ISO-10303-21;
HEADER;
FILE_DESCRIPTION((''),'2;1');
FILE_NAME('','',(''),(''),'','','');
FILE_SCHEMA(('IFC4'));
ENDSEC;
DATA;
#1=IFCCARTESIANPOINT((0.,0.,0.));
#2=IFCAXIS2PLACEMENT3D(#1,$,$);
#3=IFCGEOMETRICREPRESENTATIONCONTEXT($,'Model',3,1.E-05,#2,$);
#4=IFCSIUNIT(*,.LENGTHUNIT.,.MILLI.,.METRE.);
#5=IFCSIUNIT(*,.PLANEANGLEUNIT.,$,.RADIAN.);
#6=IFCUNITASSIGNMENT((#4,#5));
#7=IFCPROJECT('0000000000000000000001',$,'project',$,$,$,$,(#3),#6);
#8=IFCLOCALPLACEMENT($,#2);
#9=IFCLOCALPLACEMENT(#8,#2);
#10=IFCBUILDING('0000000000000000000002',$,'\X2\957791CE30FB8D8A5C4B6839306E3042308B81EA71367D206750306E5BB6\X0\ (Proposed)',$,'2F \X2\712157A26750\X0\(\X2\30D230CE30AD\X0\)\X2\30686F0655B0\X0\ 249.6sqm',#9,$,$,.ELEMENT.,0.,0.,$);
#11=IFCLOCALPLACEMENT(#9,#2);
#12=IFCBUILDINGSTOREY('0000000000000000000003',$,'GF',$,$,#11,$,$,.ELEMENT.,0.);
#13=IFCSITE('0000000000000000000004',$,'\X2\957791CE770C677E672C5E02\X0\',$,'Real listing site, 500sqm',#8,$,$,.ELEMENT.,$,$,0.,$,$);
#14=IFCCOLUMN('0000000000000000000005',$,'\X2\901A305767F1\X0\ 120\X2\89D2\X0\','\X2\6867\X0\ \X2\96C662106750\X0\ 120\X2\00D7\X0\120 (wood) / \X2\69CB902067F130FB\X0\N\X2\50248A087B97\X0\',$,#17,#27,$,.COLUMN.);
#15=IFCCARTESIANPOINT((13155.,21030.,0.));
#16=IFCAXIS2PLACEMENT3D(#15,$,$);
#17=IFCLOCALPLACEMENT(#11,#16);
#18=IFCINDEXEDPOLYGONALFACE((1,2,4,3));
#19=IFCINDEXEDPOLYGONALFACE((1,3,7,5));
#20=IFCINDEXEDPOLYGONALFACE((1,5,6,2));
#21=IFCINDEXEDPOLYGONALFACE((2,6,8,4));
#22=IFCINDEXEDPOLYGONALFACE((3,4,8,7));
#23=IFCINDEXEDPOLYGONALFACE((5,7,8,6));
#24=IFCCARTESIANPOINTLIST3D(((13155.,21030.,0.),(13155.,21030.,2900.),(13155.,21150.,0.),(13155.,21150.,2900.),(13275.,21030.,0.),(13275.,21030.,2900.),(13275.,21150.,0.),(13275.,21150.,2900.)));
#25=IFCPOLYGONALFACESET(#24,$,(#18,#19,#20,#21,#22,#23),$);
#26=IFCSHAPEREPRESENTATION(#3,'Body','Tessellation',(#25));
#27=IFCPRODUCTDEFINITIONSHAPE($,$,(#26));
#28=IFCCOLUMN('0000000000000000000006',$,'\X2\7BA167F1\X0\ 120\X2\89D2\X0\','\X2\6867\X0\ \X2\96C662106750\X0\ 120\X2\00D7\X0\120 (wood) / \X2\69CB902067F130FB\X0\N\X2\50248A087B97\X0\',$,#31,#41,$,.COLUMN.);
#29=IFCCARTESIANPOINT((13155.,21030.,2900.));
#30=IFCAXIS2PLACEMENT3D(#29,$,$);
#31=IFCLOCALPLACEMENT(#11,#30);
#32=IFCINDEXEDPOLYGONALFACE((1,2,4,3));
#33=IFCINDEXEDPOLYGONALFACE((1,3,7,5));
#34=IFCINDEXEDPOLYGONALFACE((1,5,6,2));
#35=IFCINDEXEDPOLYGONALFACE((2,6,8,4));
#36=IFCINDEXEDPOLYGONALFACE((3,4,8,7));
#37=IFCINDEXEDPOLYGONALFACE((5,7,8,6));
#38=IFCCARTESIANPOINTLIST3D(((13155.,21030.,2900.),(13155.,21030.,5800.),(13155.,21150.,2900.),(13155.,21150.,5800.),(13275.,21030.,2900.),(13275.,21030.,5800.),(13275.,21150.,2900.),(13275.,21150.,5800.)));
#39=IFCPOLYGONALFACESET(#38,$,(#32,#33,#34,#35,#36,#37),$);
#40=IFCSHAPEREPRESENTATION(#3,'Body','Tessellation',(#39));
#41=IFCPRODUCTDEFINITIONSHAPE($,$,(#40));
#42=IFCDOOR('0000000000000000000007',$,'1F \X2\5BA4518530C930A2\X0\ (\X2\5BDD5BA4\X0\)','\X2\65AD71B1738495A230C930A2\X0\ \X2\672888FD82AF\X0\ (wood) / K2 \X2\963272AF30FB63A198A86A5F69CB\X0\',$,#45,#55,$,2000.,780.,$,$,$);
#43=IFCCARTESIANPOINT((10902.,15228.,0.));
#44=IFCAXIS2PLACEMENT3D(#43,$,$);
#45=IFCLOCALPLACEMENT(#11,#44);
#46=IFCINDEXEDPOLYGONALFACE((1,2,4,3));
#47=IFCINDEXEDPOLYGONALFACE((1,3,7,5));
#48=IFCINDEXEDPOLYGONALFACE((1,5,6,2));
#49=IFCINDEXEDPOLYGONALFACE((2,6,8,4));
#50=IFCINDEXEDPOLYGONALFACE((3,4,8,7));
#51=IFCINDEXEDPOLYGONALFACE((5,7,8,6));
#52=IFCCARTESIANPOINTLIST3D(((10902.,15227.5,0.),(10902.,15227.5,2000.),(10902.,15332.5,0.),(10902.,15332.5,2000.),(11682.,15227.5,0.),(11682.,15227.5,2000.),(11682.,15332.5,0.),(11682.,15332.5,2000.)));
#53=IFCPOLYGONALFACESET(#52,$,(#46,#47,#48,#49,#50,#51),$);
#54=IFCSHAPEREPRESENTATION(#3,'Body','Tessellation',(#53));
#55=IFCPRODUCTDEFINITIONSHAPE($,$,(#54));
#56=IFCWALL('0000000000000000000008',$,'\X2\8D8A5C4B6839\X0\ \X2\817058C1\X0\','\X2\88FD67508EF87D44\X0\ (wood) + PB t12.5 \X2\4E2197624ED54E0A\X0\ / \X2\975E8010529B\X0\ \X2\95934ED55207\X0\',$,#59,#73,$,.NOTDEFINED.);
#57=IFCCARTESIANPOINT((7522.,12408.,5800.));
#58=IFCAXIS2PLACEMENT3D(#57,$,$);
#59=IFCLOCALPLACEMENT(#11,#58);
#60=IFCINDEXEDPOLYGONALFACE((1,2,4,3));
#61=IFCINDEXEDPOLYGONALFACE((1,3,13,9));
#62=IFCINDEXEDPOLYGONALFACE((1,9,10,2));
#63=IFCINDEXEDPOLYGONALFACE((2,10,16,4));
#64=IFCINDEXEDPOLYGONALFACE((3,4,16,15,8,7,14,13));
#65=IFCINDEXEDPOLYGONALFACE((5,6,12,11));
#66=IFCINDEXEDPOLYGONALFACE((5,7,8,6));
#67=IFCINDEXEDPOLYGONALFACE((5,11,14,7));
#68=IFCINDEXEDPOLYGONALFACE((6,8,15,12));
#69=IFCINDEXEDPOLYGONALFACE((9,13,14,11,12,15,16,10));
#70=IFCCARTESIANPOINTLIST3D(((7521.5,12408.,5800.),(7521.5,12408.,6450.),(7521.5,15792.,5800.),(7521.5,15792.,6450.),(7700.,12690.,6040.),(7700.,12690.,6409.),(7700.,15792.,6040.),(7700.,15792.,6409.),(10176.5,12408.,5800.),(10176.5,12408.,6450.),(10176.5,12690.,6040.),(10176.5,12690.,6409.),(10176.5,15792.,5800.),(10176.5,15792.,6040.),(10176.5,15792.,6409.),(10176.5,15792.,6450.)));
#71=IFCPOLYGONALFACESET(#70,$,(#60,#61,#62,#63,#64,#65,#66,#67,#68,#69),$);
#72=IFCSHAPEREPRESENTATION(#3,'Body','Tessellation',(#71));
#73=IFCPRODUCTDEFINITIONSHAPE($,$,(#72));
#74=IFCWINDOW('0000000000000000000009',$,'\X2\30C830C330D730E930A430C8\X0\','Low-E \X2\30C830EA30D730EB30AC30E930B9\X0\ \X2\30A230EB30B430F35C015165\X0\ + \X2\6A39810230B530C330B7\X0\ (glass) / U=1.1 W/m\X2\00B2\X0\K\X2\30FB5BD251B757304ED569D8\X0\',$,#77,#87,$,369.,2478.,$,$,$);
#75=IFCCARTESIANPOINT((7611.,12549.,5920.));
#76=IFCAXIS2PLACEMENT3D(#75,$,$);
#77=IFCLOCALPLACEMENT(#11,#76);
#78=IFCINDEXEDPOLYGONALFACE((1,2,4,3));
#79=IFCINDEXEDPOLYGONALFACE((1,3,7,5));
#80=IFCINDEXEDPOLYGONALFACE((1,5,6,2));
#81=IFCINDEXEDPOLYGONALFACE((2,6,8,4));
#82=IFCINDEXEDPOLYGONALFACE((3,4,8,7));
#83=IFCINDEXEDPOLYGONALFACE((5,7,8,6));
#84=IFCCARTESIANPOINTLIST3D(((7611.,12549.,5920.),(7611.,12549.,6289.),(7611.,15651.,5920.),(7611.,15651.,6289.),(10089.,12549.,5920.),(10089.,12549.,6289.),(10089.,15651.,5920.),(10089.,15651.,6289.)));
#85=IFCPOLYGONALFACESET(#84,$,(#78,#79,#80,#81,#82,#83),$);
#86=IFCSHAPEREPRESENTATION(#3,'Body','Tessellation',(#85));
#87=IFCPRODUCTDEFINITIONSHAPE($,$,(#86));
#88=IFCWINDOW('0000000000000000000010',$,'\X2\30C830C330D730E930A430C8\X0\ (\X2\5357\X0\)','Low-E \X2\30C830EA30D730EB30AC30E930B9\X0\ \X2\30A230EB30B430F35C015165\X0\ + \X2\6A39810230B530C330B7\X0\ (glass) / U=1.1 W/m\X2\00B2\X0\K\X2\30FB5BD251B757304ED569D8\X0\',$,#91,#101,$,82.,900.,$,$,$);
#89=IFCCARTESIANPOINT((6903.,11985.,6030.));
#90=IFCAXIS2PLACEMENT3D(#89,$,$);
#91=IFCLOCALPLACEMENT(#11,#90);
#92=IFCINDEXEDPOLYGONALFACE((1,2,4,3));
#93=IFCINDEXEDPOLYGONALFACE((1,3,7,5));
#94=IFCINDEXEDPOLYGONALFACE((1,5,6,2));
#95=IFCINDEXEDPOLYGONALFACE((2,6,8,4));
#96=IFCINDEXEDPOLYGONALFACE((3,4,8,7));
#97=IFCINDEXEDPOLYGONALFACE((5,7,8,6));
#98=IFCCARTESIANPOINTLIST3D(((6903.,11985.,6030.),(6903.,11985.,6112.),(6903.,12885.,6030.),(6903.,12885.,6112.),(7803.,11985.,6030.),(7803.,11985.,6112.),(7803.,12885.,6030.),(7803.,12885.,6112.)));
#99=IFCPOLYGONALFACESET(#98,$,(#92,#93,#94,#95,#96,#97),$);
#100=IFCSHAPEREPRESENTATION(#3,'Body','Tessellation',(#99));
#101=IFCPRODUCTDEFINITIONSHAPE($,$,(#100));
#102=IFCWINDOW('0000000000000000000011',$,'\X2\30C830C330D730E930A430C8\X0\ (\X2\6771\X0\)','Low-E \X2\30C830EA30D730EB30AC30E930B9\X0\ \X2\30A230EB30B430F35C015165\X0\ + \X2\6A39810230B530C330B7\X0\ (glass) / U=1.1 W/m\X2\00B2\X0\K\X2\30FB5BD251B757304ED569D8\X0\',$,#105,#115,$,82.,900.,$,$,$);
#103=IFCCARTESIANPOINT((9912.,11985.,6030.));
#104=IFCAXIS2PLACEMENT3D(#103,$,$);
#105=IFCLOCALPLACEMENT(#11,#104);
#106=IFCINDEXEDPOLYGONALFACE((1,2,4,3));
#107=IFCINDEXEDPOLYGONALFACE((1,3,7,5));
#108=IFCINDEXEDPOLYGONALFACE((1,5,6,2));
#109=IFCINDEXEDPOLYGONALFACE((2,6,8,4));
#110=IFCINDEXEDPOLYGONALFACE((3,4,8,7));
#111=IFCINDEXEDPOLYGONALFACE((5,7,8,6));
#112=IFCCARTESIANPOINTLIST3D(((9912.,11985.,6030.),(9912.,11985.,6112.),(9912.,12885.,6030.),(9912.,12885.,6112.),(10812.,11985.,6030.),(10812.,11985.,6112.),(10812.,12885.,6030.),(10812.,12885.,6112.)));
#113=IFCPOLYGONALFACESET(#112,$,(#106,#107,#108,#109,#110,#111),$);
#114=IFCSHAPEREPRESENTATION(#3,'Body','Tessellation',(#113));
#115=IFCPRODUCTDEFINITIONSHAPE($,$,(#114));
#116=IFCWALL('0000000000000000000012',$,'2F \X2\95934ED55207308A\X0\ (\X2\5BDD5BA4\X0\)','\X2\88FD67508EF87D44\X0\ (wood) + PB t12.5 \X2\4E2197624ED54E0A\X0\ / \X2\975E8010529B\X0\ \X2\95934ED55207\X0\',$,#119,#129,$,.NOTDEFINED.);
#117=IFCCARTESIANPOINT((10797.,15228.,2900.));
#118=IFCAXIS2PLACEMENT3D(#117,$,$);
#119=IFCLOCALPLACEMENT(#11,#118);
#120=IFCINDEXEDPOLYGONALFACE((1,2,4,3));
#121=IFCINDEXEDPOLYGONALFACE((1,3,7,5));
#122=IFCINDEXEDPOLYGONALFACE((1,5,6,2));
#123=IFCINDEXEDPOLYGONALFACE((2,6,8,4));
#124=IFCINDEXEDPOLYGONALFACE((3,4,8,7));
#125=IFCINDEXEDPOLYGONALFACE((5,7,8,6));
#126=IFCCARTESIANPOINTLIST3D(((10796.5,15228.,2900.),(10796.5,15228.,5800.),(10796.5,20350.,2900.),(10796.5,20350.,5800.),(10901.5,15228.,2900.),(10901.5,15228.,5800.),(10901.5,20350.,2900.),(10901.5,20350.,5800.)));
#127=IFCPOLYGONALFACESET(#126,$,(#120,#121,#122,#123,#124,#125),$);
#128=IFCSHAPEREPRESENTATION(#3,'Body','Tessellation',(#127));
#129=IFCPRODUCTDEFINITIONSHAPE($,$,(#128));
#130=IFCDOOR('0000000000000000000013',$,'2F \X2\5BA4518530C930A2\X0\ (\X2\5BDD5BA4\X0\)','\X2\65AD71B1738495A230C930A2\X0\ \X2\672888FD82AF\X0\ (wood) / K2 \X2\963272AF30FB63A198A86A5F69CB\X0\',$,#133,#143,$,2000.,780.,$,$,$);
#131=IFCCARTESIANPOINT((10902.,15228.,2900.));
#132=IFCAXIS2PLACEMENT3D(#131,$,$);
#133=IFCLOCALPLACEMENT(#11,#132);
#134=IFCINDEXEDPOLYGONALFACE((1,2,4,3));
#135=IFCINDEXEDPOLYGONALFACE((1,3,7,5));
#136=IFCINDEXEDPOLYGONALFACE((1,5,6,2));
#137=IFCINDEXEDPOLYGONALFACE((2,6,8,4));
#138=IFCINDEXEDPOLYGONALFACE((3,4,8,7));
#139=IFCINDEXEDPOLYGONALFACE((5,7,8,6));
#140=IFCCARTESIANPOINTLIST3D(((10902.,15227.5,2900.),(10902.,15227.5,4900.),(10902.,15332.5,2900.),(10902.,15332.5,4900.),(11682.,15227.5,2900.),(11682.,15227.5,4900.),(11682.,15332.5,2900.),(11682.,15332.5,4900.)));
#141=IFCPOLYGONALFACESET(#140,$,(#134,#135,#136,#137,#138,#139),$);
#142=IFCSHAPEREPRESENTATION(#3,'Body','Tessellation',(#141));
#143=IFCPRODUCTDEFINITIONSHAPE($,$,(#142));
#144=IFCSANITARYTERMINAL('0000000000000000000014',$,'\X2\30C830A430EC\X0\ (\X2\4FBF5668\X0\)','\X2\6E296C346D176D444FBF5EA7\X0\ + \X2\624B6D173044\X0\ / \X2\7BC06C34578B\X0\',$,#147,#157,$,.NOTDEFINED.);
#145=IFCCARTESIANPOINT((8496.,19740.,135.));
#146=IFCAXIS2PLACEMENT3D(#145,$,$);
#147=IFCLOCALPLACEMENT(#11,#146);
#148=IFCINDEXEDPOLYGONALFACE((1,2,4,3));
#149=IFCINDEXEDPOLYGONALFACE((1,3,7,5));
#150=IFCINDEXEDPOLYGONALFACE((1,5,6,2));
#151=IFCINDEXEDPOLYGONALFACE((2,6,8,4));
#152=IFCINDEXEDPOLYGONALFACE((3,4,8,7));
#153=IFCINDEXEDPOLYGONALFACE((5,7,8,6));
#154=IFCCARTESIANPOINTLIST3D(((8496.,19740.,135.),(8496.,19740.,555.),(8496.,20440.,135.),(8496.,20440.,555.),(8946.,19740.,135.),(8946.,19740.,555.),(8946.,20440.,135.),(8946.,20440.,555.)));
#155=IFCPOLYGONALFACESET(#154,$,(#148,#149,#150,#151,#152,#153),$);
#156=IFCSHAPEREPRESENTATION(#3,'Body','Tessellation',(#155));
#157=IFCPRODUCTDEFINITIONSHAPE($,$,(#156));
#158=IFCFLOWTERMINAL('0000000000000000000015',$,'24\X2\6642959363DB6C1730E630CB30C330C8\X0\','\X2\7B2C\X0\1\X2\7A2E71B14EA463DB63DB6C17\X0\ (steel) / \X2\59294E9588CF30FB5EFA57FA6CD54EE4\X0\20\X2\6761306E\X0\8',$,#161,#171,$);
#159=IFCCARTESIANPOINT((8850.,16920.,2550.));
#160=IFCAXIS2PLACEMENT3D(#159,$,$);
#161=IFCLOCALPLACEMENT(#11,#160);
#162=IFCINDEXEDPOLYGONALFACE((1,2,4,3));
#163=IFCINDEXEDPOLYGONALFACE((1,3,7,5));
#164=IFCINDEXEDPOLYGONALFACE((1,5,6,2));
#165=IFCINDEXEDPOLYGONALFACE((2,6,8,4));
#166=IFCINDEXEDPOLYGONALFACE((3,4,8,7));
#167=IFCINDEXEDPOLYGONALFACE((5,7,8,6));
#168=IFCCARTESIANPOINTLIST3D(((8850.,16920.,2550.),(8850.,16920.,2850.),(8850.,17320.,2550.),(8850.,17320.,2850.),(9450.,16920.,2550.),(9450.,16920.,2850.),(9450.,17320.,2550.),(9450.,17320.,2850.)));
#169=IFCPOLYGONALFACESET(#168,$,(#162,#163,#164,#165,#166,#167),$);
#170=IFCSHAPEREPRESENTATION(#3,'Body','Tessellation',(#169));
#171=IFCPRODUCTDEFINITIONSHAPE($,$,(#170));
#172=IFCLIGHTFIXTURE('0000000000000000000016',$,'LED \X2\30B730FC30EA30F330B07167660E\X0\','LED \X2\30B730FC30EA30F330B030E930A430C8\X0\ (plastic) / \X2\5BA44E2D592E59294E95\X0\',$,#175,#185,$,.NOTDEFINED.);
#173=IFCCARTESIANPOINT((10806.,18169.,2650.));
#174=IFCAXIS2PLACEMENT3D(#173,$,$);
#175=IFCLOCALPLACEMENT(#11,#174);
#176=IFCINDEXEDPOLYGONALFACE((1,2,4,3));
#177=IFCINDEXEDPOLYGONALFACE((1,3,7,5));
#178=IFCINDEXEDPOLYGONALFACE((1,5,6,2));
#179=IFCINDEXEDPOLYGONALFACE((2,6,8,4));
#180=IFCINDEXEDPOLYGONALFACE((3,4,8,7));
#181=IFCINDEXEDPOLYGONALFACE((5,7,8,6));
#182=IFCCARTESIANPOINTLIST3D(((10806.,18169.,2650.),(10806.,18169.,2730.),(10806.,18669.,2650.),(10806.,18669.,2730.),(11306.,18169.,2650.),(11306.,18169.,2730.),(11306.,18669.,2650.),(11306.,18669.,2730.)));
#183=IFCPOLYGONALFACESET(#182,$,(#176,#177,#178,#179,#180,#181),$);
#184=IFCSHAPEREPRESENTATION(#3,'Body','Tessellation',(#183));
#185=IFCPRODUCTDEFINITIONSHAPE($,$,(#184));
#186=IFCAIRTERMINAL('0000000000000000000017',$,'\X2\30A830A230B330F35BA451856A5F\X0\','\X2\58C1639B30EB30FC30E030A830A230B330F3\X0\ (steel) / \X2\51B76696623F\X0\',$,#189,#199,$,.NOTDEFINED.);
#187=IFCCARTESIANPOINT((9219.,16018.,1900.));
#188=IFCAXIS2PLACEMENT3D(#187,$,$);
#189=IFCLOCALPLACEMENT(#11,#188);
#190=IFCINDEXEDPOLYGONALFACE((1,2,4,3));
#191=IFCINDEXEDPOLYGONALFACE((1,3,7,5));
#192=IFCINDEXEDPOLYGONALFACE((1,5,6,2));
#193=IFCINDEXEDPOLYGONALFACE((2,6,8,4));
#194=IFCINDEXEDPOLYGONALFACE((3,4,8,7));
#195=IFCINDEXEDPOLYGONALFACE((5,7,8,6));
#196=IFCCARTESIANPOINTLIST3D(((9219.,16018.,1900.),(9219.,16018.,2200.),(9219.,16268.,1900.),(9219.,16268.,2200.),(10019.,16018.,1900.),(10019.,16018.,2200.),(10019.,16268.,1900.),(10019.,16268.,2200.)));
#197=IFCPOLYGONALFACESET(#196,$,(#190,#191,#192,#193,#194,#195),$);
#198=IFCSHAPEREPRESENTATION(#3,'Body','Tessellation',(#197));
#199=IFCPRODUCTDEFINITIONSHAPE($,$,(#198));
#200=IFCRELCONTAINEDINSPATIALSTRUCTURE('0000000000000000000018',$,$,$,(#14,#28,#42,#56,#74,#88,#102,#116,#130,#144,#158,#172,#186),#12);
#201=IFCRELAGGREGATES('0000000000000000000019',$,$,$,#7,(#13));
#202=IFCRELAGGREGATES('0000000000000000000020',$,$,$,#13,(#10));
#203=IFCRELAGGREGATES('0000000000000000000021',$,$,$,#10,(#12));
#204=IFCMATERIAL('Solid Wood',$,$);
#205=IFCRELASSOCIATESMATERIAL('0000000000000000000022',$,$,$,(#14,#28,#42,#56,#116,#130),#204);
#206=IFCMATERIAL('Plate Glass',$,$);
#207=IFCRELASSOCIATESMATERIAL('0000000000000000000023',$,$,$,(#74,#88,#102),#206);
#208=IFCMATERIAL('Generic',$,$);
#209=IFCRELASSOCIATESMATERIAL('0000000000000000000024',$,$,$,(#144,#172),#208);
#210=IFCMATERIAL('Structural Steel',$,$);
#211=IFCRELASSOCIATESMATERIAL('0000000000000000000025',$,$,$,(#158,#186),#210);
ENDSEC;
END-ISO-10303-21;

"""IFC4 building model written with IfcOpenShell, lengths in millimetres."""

from ifc_helpers import new_model, si_unit, frame, frame_2d, origin, place, context, project, spatial, rectangle, extrude, material, element, fill, save


model = new_model("IFC4")

# Units and contexts
model_context = context("Model", 3, precision=1e-05, world=origin())
ifc_project = project(units=[si_unit("LENGTHUNIT", "METRE", prefix="MILLI"), si_unit("PLANEANGLEUNIT", "RADIAN")], contexts=[model_context])

# Site, building, storey
site_placement = place(None, origin())
site = spatial("IfcSite", under=ifc_project, at=site_placement, Name="長野県松本市", ObjectType="Real listing site, 500sqm", CompositionType="ELEMENT", RefElevation=0.0)
building_placement = place(site_placement, origin())
building = spatial("IfcBuilding", under=site, at=building_placement, Name="長野・越屋根のある自然素材の家 (Proposed)", ObjectType="2F 無垢材(ヒノキ)と漆喰 249.6sqm", CompositionType="ELEMENT", ElevationOfRefHeight=0.0, ElevationOfTerrain=0.0)
storey_placement = place(building_placement, origin())
storey = spatial("IfcBuildingStorey", under=building, at=storey_placement, Name="GF", CompositionType="ELEMENT", Elevation=0.0)

# Columns
ifc_material_1 = material(Name="Solid Wood")
column_1_placement = place(storey_placement, frame((13155.0, 21030.0, 0.0)))
element("IfcColumn", 1, at=column_1_placement, inside=storey, material=ifc_material_1, Name="通し柱 120角", Description="桧 集成材 120×120 (wood) / 構造柱・N値計算", PredefinedType="COLUMN", context=model_context, shape_type="SweptSolid", body=[
    extrude(rectangle(XDim=120.0, YDim=120.0, at=frame_2d((60.0, 60.0))), frame((13155.0, 21030.0, 0.0)), (0.0, 0.0, 1.0), 2900.0),
])
column_2_placement = place(storey_placement, frame((13155.0, 21030.0, 2900.0)))
element("IfcColumn", 2, at=column_2_placement, inside=storey, material=ifc_material_1, Name="管柱 120角", Description="桧 集成材 120×120 (wood) / 構造柱・N値計算", PredefinedType="COLUMN", context=model_context, shape_type="SweptSolid", body=[
    extrude(rectangle(XDim=120.0, YDim=120.0, at=frame_2d((60.0, 60.0))), frame((13155.0, 21030.0, 2900.0)), (0.0, 0.0, 1.0), 2900.0),
])

# Door
door_1_placement = place(storey_placement, frame((10902.0, 15228.0, 0.0)))
element("IfcDoor", 3, at=door_1_placement, inside=storey, material=ifc_material_1, Name="1F 室内ドア (寝室)", Description="断熱玄関ドア 木製芯 (wood) / K2 防犯・採風機構", OverallHeight=2000.0, OverallWidth=780.0, context=model_context, shape_type="SweptSolid", body=[
    extrude(rectangle(XDim=780.0, YDim=105.0, at=frame_2d((390.0, 52.0))), frame((10902.0, 15228.0, 0.0)), (0.0, 0.0, 1.0), 2000.0),
])

# Wall, openings, windows
wall_1_placement = place(storey_placement, frame((7522.0, 12408.0, 5800.0)))
wall_1 = element("IfcWall", 4, at=wall_1_placement, inside=storey, material=ifc_material_1, Name="越屋根 腰壁", Description="製材軸組 (wood) + PB t12.5 両面仕上 / 非耐力 間仕切", PredefinedType="NOTDEFINED", context=model_context, shape_type="SweptSolid", body=[
    extrude(rectangle(XDim=2655.0, YDim=3384.0, at=frame_2d((1327.0, 1692.0))), frame((7522.0, 12408.0, 5800.0)), (0.0, 0.0, 1.0), 650.0),
])
opening_1_placement = place(storey_placement, frame((7611.0, 12549.0, 5920.0)))
opening_1 = element("IfcOpeningElement", 5, at=opening_1_placement, cuts=wall_1, PredefinedType="NOTDEFINED", context=model_context, shape_type="SweptSolid", body=[
    extrude(rectangle(XDim=2478.0, YDim=3102.0, at=frame_2d((1239.0, 1551.0))), frame((7611.0, 12549.0, 5920.0)), (0.0, 0.0, 1.0), 369.0),
])
opening_2_placement = place(storey_placement, frame((6903.0, 11985.0, 6030.0)))
opening_2 = element("IfcOpeningElement", 6, at=opening_2_placement, cuts=wall_1, PredefinedType="NOTDEFINED", context=model_context, shape_type="SweptSolid", body=[
    extrude(rectangle(XDim=900.0, YDim=900.0, at=frame_2d((450.0, 450.0))), frame((6903.0, 11985.0, 6030.0)), (0.0, 0.0, 1.0), 82.0),
])
opening_3_placement = place(storey_placement, frame((9912.0, 11985.0, 6030.0)))
opening_3 = element("IfcOpeningElement", 7, at=opening_3_placement, cuts=wall_1, PredefinedType="NOTDEFINED", context=model_context, shape_type="SweptSolid", body=[
    extrude(rectangle(XDim=900.0, YDim=900.0, at=frame_2d((450.0, 450.0))), frame((9912.0, 11985.0, 6030.0)), (0.0, 0.0, 1.0), 82.0),
])
ifc_material_2 = material(Name="Plate Glass")
window_1_placement = place(storey_placement, frame((7611.0, 12549.0, 5920.0)))
window_1 = element("IfcWindow", 8, at=window_1_placement, inside=storey, material=ifc_material_2, Name="トップライト", Description="Low-E トリプルガラス アルゴン封入 + 樹脂サッシ (glass) / U=1.1 W/m²K・寒冷地仕様", OverallHeight=369.0, OverallWidth=2478.0, context=model_context, shape_type="SweptSolid", body=[
    extrude(rectangle(XDim=2478.0, YDim=3102.0, at=frame_2d((1239.0, 1551.0))), frame((7611.0, 12549.0, 5920.0)), (0.0, 0.0, 1.0), 369.0),
])
fill(opening_1, window_1)
window_2_placement = place(storey_placement, frame((6903.0, 11985.0, 6030.0)))
window_2 = element("IfcWindow", 9, at=window_2_placement, inside=storey, material=ifc_material_2, Name="トップライト (南)", Description="Low-E トリプルガラス アルゴン封入 + 樹脂サッシ (glass) / U=1.1 W/m²K・寒冷地仕様", OverallHeight=82.0, OverallWidth=900.0, context=model_context, shape_type="SweptSolid", body=[
    extrude(rectangle(XDim=900.0, YDim=900.0, at=frame_2d((450.0, 450.0))), frame((6903.0, 11985.0, 6030.0)), (0.0, 0.0, 1.0), 82.0),
])
fill(opening_2, window_2)
window_3_placement = place(storey_placement, frame((9912.0, 11985.0, 6030.0)))
window_3 = element("IfcWindow", 10, at=window_3_placement, inside=storey, material=ifc_material_2, Name="トップライト (東)", Description="Low-E トリプルガラス アルゴン封入 + 樹脂サッシ (glass) / U=1.1 W/m²K・寒冷地仕様", OverallHeight=82.0, OverallWidth=900.0, context=model_context, shape_type="SweptSolid", body=[
    extrude(rectangle(XDim=900.0, YDim=900.0, at=frame_2d((450.0, 450.0))), frame((9912.0, 11985.0, 6030.0)), (0.0, 0.0, 1.0), 82.0),
])
fill(opening_3, window_3)

# Wall
wall_2_placement = place(storey_placement, frame((10797.0, 15228.0, 2900.0)))
element("IfcWall", 11, at=wall_2_placement, inside=storey, material=ifc_material_1, Name="2F 間仕切り (寝室)", Description="製材軸組 (wood) + PB t12.5 両面仕上 / 非耐力 間仕切", PredefinedType="NOTDEFINED", context=model_context, shape_type="SweptSolid", body=[
    extrude(rectangle(XDim=105.0, YDim=5122.0, at=frame_2d((52.0, 2561.0))), frame((10797.0, 15228.0, 2900.0)), (0.0, 0.0, 1.0), 2900.0),
])

# Door
door_2_placement = place(storey_placement, frame((10902.0, 15228.0, 2900.0)))
element("IfcDoor", 12, at=door_2_placement, inside=storey, material=ifc_material_1, Name="2F 室内ドア (寝室)", Description="断熱玄関ドア 木製芯 (wood) / K2 防犯・採風機構", OverallHeight=2000.0, OverallWidth=780.0, context=model_context, shape_type="SweptSolid", body=[
    extrude(rectangle(XDim=780.0, YDim=105.0, at=frame_2d((390.0, 52.0))), frame((10902.0, 15228.0, 2900.0)), (0.0, 0.0, 1.0), 2000.0),
])

# Sanitary terminal
ifc_material_3 = material(Name="Generic")
sanitary_terminal_placement = place(storey_placement, frame((8496.0, 19740.0, 135.0)))
element("IfcSanitaryTerminal", 13, at=sanitary_terminal_placement, inside=storey, material=ifc_material_3, Name="トイレ (便器)", Description="温水洗浄便座 + 手洗い / 節水型", PredefinedType="NOTDEFINED", context=model_context, shape_type="SweptSolid", body=[
    extrude(rectangle(XDim=450.0, YDim=700.0, at=frame_2d((225.0, 350.0))), frame((8496.0, 19740.0, 135.0)), (0.0, 0.0, 1.0), 420.0),
])

# Flow terminal
ifc_material_4 = material(Name="Structural Steel")
flow_terminal_placement = place(storey_placement, frame((8850.0, 16920.0, 2550.0)))
element("IfcFlowTerminal", 14, at=flow_terminal_placement, inside=storey, material=ifc_material_4, Name="24時間換気ユニット", Description="第1種熱交換換気 (steel) / 天井裏・建基法令20条の8", context=model_context, shape_type="SweptSolid", body=[
    extrude(rectangle(XDim=600.0, YDim=400.0, at=frame_2d((300.0, 200.0))), frame((8850.0, 16920.0, 2550.0)), (0.0, 0.0, 1.0), 300.0),
])

# Light fixture
light_fixture_1_placement = place(storey_placement, frame((10806.0, 18169.0, 2650.0)))
element("IfcLightFixture", 15, at=light_fixture_1_placement, inside=storey, material=ifc_material_3, Name="LED シーリング照明", Description="LED シーリングライト (plastic) / 室中央天井", PredefinedType="NOTDEFINED", context=model_context, shape_type="SweptSolid", body=[
    extrude(rectangle(XDim=500.0, YDim=500.0, at=frame_2d((250.0, 250.0))), frame((10806.0, 18169.0, 2650.0)), (0.0, 0.0, 1.0), 80.0),
])

# Air terminal
air_terminal_placement = place(storey_placement, frame((9219.0, 16018.0, 1900.0)))
element("IfcAirTerminal", 16, at=air_terminal_placement, inside=storey, material=ifc_material_4, Name="エアコン室内機", Description="壁掛ルームエアコン (steel) / 冷暖房", PredefinedType="NOTDEFINED", context=model_context, shape_type="SweptSolid", body=[
    extrude(rectangle(XDim=800.0, YDim=250.0, at=frame_2d((400.0, 125.0))), frame((9219.0, 16018.0, 1900.0)), (0.0, 0.0, 1.0), 300.0),
])

save(model, "model.ifc")
